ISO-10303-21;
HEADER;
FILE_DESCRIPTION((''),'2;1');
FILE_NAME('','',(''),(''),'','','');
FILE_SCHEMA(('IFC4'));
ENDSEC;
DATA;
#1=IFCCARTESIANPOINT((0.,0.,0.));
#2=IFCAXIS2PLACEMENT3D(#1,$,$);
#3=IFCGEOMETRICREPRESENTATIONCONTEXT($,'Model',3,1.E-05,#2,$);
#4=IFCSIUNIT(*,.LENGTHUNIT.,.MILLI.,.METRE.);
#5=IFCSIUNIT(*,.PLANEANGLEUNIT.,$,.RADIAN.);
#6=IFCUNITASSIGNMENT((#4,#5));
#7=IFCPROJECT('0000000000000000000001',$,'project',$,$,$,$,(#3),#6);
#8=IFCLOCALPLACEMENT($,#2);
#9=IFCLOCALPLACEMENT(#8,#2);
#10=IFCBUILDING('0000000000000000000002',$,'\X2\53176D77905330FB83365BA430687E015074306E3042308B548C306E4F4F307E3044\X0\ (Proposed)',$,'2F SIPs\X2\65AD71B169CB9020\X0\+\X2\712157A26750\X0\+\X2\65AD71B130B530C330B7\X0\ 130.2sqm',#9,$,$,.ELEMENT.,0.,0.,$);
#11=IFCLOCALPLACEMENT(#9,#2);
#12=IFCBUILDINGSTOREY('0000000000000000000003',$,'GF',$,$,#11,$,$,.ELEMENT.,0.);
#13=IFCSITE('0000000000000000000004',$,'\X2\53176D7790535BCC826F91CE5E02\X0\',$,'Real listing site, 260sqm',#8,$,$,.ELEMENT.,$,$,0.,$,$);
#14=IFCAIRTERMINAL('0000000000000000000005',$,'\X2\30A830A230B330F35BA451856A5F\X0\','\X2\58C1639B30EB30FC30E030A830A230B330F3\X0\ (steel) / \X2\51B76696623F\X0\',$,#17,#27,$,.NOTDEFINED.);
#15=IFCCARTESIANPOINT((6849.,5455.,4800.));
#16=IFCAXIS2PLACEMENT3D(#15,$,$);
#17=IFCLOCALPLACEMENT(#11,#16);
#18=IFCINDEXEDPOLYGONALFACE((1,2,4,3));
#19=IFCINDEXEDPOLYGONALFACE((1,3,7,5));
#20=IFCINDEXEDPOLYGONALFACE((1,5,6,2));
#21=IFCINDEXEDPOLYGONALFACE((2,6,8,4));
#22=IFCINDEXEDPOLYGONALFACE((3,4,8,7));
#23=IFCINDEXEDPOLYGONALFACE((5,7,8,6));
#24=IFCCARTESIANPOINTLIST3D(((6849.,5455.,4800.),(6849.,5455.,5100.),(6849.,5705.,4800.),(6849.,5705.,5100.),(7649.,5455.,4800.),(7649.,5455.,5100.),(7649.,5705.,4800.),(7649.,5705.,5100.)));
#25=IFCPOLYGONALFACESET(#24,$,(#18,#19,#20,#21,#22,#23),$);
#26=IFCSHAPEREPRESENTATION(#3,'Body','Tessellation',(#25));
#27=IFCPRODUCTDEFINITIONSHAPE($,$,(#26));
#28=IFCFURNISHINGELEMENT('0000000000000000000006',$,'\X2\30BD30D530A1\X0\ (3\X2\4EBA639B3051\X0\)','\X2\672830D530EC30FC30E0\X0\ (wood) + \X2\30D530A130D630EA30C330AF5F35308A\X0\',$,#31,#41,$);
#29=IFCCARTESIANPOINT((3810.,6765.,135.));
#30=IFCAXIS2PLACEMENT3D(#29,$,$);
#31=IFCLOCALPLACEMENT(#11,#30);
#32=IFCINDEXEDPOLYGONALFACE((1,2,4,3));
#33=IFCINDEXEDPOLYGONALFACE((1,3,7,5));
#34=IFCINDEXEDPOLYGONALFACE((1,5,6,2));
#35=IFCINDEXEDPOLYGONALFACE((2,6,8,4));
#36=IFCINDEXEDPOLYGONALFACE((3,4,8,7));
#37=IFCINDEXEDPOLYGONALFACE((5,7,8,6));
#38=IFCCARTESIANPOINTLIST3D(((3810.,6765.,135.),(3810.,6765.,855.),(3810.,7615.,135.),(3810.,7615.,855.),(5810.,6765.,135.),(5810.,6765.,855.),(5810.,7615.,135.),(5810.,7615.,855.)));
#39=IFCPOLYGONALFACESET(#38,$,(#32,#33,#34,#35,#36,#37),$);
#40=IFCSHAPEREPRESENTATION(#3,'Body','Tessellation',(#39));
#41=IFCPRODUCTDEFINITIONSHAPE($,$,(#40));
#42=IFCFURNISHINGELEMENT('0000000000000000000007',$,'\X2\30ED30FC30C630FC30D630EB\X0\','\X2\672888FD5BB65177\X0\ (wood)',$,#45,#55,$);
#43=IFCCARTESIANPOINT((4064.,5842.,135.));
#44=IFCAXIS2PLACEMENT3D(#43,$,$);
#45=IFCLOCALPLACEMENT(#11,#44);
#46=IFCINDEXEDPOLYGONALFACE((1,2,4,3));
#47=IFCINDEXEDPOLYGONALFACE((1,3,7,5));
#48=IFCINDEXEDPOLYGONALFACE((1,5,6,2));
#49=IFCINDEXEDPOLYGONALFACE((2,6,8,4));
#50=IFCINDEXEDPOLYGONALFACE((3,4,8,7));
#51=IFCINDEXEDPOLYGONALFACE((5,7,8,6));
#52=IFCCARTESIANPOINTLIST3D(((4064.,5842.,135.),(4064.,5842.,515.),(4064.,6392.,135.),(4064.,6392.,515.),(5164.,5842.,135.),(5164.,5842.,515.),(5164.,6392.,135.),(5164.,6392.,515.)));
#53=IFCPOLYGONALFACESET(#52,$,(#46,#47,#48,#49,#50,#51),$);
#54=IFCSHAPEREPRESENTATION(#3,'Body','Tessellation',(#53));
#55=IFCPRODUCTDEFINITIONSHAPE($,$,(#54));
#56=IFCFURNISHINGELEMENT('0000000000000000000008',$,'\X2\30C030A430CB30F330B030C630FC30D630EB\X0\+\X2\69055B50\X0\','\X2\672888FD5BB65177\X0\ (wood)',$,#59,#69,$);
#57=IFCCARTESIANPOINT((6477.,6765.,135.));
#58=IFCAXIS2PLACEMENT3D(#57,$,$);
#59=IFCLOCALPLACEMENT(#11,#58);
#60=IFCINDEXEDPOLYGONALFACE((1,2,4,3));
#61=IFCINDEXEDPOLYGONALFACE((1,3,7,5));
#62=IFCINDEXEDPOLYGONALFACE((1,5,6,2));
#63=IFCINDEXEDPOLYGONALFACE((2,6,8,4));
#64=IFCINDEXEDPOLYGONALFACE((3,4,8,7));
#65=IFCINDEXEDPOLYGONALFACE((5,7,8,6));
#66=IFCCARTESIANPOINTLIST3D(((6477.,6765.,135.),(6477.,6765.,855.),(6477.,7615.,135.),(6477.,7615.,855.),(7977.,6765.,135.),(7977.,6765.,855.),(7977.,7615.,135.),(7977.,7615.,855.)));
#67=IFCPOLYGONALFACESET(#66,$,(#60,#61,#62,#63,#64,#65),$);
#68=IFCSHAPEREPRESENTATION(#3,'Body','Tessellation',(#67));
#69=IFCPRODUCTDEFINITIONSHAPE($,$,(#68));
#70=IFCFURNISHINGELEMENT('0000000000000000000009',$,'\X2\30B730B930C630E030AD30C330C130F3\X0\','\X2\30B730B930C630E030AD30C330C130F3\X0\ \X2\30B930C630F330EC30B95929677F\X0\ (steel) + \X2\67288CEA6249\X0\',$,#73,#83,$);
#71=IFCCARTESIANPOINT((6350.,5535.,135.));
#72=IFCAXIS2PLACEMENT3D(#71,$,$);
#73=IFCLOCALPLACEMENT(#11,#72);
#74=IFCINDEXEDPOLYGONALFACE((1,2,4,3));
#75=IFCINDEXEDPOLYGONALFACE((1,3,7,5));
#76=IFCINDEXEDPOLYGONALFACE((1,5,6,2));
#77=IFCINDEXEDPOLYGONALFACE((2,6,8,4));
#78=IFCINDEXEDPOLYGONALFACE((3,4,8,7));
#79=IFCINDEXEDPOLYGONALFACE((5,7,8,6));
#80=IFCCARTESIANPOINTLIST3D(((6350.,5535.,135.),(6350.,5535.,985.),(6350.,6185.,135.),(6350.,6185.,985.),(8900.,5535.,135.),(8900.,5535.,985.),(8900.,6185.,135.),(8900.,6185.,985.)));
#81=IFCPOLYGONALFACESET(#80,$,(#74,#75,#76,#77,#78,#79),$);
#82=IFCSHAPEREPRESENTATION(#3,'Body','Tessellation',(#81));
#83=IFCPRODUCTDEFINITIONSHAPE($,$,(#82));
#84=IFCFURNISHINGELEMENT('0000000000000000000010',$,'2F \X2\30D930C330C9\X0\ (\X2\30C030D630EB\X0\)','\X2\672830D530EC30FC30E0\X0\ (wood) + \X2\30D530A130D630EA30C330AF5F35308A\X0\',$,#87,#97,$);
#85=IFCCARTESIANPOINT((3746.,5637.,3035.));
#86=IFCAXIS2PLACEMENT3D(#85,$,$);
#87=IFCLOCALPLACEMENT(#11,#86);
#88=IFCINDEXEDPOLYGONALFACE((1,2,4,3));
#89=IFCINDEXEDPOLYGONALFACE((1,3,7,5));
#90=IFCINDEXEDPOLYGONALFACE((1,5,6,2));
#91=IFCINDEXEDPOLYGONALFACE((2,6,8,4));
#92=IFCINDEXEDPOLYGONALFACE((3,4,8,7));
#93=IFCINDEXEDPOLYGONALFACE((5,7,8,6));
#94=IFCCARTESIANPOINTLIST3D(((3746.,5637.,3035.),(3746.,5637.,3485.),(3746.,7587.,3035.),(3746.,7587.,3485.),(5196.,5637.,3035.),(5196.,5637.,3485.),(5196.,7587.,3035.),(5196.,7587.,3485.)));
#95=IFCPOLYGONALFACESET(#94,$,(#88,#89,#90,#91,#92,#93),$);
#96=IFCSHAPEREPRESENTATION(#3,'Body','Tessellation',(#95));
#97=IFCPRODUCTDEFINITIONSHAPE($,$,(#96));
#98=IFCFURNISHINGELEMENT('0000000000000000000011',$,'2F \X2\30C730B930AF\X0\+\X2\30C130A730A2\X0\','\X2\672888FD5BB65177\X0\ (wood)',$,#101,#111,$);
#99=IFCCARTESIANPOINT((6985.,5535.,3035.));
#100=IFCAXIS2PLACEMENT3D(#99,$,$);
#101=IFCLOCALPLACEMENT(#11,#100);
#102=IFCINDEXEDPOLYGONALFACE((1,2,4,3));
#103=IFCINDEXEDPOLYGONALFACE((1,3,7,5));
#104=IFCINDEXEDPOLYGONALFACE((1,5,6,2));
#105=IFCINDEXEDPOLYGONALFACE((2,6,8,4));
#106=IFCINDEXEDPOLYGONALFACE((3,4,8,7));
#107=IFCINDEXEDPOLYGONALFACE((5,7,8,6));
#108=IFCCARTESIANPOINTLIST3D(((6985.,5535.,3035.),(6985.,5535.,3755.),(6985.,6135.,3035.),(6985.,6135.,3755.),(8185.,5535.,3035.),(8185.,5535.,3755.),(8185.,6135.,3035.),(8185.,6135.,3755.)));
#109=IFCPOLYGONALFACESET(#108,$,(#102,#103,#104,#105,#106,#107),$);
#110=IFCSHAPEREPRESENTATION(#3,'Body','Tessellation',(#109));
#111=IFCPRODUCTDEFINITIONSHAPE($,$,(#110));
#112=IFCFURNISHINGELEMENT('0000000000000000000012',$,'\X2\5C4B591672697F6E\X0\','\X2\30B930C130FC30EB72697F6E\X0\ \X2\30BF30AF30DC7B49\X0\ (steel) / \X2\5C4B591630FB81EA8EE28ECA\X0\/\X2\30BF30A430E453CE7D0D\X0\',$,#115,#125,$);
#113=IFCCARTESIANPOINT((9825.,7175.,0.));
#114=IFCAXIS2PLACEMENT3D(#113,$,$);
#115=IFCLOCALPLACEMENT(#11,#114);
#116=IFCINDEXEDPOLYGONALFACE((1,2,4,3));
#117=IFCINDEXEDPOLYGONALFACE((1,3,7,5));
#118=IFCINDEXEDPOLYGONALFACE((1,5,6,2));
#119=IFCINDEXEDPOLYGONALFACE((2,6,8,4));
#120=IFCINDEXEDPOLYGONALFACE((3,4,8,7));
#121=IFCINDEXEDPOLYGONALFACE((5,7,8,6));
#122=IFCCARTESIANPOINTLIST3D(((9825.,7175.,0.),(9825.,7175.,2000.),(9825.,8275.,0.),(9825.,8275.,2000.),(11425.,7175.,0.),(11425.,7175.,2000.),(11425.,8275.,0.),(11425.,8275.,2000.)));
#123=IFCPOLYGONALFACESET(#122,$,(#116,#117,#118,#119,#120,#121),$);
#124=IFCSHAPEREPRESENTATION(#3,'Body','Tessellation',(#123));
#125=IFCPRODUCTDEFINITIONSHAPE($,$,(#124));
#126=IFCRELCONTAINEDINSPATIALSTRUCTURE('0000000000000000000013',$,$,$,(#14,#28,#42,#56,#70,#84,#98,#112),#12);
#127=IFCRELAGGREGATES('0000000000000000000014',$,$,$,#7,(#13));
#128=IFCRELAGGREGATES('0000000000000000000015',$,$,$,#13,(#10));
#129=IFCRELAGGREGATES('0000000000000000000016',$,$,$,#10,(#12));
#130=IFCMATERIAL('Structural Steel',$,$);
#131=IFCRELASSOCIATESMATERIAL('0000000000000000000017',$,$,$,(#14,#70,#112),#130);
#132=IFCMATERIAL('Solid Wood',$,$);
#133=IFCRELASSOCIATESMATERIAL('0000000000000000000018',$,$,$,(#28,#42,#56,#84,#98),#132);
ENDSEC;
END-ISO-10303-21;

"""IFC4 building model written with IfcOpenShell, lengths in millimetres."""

from ifc_helpers import new_model, si_unit, frame, frame_2d, origin, place, context, project, spatial, rectangle, extrude, material, element, save


model = new_model("IFC4")

# Units and contexts
model_context = context("Model", 3, precision=1e-05, world=origin())
ifc_project = project(units=[si_unit("LENGTHUNIT", "METRE", prefix="MILLI"), si_unit("PLANEANGLEUNIT", "RADIAN")], contexts=[model_context])

# Site, building, storey
site_placement = place(None, origin())
site = spatial("IfcSite", under=ifc_project, at=site_placement, Name="北海道富良野市", ObjectType="Real listing site, 260sqm", CompositionType="ELEMENT", RefElevation=0.0)
building_placement = place(site_placement, origin())
building = spatial("IfcBuilding", under=site, at=building_placement, Name="北海道・茶室と縁側のある和の住まい (Proposed)", ObjectType="2F SIPs断熱構造+無垢材+断熱サッシ 130.2sqm", CompositionType="ELEMENT", ElevationOfRefHeight=0.0, ElevationOfTerrain=0.0)
storey_placement = place(building_placement, origin())
storey = spatial("IfcBuildingStorey", under=building, at=storey_placement, Name="GF", CompositionType="ELEMENT", Elevation=0.0)

# Shared definitions
ifc_material_1 = material(Name="Solid Wood")

# Shared definitions
ifc_material_2 = material(Name="Structural Steel")

# Air terminal
air_terminal_1_placement = place(storey_placement, frame((6849.0, 5455.0, 4800.0)))
element("IfcAirTerminal", 1, at=air_terminal_1_placement, inside=storey, material=ifc_material_2, Name="エアコン室内機", Description="壁掛ルームエアコン (steel) / 冷暖房", PredefinedType="NOTDEFINED", context=model_context, shape_type="SweptSolid", body=[
    extrude(rectangle(XDim=800.0, YDim=250.0, at=frame_2d((400.0, 125.0))), frame((6849.0, 5455.0, 4800.0)), (0.0, 0.0, 1.0), 300.0),
])

# Furnishing elements
furnishing_1_placement = place(storey_placement, frame((3810.0, 6765.0, 135.0)))
element("IfcFurnishingElement", 2, at=furnishing_1_placement, inside=storey, material=ifc_material_1, Name="ソファ (3人掛け)", Description="木フレーム (wood) + ファブリック張り", context=model_context, shape_type="SweptSolid", body=[
    extrude(rectangle(XDim=2000.0, YDim=850.0, at=frame_2d((1000.0, 425.0))), frame((3810.0, 6765.0, 135.0)), (0.0, 0.0, 1.0), 720.0),
])
furnishing_2_placement = place(storey_placement, frame((4064.0, 5842.0, 135.0)))
element("IfcFurnishingElement", 3, at=furnishing_2_placement, inside=storey, material=ifc_material_1, Name="ローテーブル", Description="木製家具 (wood)", context=model_context, shape_type="SweptSolid", body=[
    extrude(rectangle(XDim=1100.0, YDim=550.0, at=frame_2d((550.0, 275.0))), frame((4064.0, 5842.0, 135.0)), (0.0, 0.0, 1.0), 380.0),
])
furnishing_3_placement = place(storey_placement, frame((6477.0, 6765.0, 135.0)))
element("IfcFurnishingElement", 4, at=furnishing_3_placement, inside=storey, material=ifc_material_1, Name="ダイニングテーブル+椅子", Description="木製家具 (wood)", context=model_context, shape_type="SweptSolid", body=[
    extrude(rectangle(XDim=1500.0, YDim=850.0, at=frame_2d((750.0, 425.0))), frame((6477.0, 6765.0, 135.0)), (0.0, 0.0, 1.0), 720.0),
])
furnishing_4_placement = place(storey_placement, frame((6350.0, 5535.0, 135.0)))
element("IfcFurnishingElement", 5, at=furnishing_4_placement, inside=storey, material=ifc_material_2, Name="システムキッチン", Description="システムキッチン ステンレス天板 (steel) + 木質扉", context=model_context, shape_type="SweptSolid", body=[
    extrude(rectangle(XDim=2550.0, YDim=650.0, at=frame_2d((1275.0, 325.0))), frame((6350.0, 5535.0, 135.0)), (0.0, 0.0, 1.0), 850.0),
])
furnishing_5_placement = place(storey_placement, frame((3746.0, 5637.0, 3035.0)))
element("IfcFurnishingElement", 6, at=furnishing_5_placement, inside=storey, material=ifc_material_1, Name="2F ベッド (ダブル)", Description="木フレーム (wood) + ファブリック張り", context=model_context, shape_type="SweptSolid", body=[
    extrude(rectangle(XDim=1450.0, YDim=1950.0, at=frame_2d((725.0, 975.0))), frame((3746.0, 5637.0, 3035.0)), (0.0, 0.0, 1.0), 450.0),
])
furnishing_6_placement = place(storey_placement, frame((6985.0, 5535.0, 3035.0)))
element("IfcFurnishingElement", 7, at=furnishing_6_placement, inside=storey, material=ifc_material_1, Name="2F デスク+チェア", Description="木製家具 (wood)", context=model_context, shape_type="SweptSolid", body=[
    extrude(rectangle(XDim=1200.0, YDim=600.0, at=frame_2d((600.0, 300.0))), frame((6985.0, 5535.0, 3035.0)), (0.0, 0.0, 1.0), 720.0),
])
furnishing_7_placement = place(storey_placement, frame((9825.0, 7175.0, 0.0)))
element("IfcFurnishingElement", 8, at=furnishing_7_placement, inside=storey, material=ifc_material_2, Name="屋外物置", Description="スチール物置 タクボ等 (steel) / 屋外・自転車/タイヤ収納", context=model_context, shape_type="SweptSolid", body=[
    extrude(rectangle(XDim=1600.0, YDim=1100.0, at=frame_2d((800.0, 550.0))), frame((9825.0, 7175.0, 0.0)), (0.0, 0.0, 1.0), 2000.0),
])

save(model, "model.ifc")
